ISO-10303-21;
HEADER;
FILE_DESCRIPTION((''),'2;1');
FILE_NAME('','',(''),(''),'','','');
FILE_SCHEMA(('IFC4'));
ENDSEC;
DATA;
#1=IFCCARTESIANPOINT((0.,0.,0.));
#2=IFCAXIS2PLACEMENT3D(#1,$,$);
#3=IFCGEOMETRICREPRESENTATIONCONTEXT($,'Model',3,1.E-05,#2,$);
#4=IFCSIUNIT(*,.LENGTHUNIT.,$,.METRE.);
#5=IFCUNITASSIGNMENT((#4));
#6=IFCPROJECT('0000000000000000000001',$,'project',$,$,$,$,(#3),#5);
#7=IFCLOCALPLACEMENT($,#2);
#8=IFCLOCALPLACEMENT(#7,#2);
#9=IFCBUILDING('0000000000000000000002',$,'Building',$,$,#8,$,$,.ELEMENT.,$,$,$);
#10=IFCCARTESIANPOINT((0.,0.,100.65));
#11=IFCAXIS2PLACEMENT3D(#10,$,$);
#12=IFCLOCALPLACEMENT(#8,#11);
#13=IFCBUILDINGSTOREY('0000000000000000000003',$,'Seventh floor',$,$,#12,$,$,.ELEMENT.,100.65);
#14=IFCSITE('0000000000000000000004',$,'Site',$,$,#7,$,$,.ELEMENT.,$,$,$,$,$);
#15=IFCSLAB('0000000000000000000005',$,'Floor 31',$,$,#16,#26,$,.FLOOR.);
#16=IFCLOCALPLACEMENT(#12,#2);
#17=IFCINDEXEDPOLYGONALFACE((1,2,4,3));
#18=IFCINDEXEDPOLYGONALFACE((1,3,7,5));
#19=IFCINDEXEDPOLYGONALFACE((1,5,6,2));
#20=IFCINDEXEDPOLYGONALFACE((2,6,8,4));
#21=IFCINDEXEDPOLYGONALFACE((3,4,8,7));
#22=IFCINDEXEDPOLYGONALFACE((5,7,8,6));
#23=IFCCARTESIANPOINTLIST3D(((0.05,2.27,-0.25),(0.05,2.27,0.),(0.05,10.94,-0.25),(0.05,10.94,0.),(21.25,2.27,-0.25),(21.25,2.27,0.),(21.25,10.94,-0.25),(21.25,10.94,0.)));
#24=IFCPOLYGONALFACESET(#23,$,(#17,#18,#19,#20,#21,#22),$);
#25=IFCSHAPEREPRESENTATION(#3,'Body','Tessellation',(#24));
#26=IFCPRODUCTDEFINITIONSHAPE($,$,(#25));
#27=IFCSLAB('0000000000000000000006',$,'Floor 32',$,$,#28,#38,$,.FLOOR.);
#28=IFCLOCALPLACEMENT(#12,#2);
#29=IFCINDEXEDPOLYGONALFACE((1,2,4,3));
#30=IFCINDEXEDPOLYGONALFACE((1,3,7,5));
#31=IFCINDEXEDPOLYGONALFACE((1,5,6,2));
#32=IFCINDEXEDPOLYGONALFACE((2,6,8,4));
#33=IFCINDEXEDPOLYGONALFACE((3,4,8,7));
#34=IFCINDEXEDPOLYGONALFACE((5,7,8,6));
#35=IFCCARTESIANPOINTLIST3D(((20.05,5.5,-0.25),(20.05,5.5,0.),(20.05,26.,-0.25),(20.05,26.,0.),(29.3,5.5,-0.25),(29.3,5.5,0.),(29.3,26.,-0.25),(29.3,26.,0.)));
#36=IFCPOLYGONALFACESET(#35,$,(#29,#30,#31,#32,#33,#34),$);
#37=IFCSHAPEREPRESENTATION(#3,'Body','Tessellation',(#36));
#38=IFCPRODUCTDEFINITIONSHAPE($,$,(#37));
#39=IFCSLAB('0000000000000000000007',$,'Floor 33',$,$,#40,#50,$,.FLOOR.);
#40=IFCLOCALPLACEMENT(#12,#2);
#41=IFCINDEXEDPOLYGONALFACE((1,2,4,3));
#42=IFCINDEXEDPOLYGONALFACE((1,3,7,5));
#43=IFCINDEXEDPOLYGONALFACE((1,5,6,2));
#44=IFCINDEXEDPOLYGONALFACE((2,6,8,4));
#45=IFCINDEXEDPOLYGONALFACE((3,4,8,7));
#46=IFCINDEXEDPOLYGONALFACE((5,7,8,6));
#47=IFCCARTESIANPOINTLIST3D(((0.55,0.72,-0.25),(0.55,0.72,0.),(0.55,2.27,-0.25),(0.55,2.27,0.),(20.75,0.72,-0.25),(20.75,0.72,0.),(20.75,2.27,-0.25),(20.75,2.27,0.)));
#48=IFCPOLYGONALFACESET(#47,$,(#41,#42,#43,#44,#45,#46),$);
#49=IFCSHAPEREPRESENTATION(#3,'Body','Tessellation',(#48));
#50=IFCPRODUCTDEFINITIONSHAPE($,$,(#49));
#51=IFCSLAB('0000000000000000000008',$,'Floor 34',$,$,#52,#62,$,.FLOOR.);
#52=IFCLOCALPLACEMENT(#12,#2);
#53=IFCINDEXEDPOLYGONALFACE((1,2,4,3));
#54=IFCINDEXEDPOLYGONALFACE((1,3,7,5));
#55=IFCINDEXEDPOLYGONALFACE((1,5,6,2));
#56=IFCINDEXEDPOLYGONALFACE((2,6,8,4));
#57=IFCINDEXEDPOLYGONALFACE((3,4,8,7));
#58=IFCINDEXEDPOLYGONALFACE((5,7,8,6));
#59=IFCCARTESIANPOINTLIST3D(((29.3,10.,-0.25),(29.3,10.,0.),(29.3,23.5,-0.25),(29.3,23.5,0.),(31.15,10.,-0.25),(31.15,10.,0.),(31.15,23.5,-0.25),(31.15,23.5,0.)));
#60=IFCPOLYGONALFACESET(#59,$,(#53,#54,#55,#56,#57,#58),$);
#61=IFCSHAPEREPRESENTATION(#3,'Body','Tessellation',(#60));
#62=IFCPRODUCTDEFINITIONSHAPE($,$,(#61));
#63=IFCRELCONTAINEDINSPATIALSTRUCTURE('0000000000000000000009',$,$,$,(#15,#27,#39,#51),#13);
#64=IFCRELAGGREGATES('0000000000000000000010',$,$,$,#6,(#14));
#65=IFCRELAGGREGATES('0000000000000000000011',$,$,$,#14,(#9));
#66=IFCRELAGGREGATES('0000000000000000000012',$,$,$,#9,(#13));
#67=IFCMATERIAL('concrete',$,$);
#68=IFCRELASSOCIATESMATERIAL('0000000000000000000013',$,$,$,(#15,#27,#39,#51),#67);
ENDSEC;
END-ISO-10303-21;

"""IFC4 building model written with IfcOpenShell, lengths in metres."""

from ifc_helpers import new_model, si_unit, frame, origin, place, context, project, spatial, polyline, outline, extrude, material, element, save


model = new_model("IFC4")

# Units and contexts
model_context = context("Model", 3, precision=1e-05, world=origin())
ifc_project = project(units=[si_unit("LENGTHUNIT", "METRE")], contexts=[model_context])

# Site, building, storey
site_placement = place(None, origin())
site = spatial("IfcSite", under=ifc_project, at=site_placement, Name="Site", CompositionType="ELEMENT")
building_placement = place(site_placement, origin())
building = spatial("IfcBuilding", under=site, at=building_placement, Name="Building", CompositionType="ELEMENT")
storey_placement = place(building_placement, frame((0.0, 0.0, 100.65)))
storey = spatial("IfcBuildingStorey", under=building, at=storey_placement, Name="Seventh floor", CompositionType="ELEMENT", Elevation=100.65)

# Slabs
ifc_material = material(Name="concrete")
slab_1_placement = place(storey_placement, frame((0.0, 0.0, -0.25), z_axis=(0.0, 0.0, 1.0), x_axis=(1.0, 0.0, 0.0)))
element("IfcSlab", 1, at=slab_1_placement, inside=storey, material=ifc_material, Name="Floor 31", PredefinedType="FLOOR", context=model_context, shape_type="SweptSolid", body=[
    extrude(outline(polyline([(0.05, 2.27), (21.25, 2.27), (21.25, 10.94), (0.05, 10.94), (0.05, 2.27)])), origin(), (0.0, 0.0, 1.0), 0.25),
])
slab_2_placement = place(storey_placement, frame((0.0, 0.0, -0.25), z_axis=(0.0, 0.0, 1.0), x_axis=(1.0, 0.0, 0.0)))
element("IfcSlab", 2, at=slab_2_placement, inside=storey, material=ifc_material, Name="Floor 32", PredefinedType="FLOOR", context=model_context, shape_type="SweptSolid", body=[
    extrude(outline(polyline([(20.05, 5.5), (29.3, 5.5), (29.3, 26.0), (20.05, 26.0), (20.05, 5.5)])), origin(), (0.0, 0.0, 1.0), 0.25),
])
slab_3_placement = place(storey_placement, frame((0.0, 0.0, -0.25), z_axis=(0.0, 0.0, 1.0), x_axis=(1.0, 0.0, 0.0)))
element("IfcSlab", 3, at=slab_3_placement, inside=storey, material=ifc_material, Name="Floor 33", PredefinedType="FLOOR", context=model_context, shape_type="SweptSolid", body=[
    extrude(outline(polyline([(0.55, 0.72), (20.75, 0.72), (20.75, 2.27), (0.55, 2.27), (0.55, 0.72)])), origin(), (0.0, 0.0, 1.0), 0.25),
])
slab_4_placement = place(storey_placement, frame((0.0, 0.0, -0.25), z_axis=(0.0, 0.0, 1.0), x_axis=(1.0, 0.0, 0.0)))
element("IfcSlab", 4, at=slab_4_placement, inside=storey, material=ifc_material, Name="Floor 34", PredefinedType="FLOOR", context=model_context, shape_type="SweptSolid", body=[
    extrude(outline(polyline([(29.3, 10.0), (31.15, 10.0), (31.15, 23.5), (29.3, 23.5), (29.3, 10.0)])), origin(), (0.0, 0.0, 1.0), 0.25),
])

save(model, "model.ifc")
